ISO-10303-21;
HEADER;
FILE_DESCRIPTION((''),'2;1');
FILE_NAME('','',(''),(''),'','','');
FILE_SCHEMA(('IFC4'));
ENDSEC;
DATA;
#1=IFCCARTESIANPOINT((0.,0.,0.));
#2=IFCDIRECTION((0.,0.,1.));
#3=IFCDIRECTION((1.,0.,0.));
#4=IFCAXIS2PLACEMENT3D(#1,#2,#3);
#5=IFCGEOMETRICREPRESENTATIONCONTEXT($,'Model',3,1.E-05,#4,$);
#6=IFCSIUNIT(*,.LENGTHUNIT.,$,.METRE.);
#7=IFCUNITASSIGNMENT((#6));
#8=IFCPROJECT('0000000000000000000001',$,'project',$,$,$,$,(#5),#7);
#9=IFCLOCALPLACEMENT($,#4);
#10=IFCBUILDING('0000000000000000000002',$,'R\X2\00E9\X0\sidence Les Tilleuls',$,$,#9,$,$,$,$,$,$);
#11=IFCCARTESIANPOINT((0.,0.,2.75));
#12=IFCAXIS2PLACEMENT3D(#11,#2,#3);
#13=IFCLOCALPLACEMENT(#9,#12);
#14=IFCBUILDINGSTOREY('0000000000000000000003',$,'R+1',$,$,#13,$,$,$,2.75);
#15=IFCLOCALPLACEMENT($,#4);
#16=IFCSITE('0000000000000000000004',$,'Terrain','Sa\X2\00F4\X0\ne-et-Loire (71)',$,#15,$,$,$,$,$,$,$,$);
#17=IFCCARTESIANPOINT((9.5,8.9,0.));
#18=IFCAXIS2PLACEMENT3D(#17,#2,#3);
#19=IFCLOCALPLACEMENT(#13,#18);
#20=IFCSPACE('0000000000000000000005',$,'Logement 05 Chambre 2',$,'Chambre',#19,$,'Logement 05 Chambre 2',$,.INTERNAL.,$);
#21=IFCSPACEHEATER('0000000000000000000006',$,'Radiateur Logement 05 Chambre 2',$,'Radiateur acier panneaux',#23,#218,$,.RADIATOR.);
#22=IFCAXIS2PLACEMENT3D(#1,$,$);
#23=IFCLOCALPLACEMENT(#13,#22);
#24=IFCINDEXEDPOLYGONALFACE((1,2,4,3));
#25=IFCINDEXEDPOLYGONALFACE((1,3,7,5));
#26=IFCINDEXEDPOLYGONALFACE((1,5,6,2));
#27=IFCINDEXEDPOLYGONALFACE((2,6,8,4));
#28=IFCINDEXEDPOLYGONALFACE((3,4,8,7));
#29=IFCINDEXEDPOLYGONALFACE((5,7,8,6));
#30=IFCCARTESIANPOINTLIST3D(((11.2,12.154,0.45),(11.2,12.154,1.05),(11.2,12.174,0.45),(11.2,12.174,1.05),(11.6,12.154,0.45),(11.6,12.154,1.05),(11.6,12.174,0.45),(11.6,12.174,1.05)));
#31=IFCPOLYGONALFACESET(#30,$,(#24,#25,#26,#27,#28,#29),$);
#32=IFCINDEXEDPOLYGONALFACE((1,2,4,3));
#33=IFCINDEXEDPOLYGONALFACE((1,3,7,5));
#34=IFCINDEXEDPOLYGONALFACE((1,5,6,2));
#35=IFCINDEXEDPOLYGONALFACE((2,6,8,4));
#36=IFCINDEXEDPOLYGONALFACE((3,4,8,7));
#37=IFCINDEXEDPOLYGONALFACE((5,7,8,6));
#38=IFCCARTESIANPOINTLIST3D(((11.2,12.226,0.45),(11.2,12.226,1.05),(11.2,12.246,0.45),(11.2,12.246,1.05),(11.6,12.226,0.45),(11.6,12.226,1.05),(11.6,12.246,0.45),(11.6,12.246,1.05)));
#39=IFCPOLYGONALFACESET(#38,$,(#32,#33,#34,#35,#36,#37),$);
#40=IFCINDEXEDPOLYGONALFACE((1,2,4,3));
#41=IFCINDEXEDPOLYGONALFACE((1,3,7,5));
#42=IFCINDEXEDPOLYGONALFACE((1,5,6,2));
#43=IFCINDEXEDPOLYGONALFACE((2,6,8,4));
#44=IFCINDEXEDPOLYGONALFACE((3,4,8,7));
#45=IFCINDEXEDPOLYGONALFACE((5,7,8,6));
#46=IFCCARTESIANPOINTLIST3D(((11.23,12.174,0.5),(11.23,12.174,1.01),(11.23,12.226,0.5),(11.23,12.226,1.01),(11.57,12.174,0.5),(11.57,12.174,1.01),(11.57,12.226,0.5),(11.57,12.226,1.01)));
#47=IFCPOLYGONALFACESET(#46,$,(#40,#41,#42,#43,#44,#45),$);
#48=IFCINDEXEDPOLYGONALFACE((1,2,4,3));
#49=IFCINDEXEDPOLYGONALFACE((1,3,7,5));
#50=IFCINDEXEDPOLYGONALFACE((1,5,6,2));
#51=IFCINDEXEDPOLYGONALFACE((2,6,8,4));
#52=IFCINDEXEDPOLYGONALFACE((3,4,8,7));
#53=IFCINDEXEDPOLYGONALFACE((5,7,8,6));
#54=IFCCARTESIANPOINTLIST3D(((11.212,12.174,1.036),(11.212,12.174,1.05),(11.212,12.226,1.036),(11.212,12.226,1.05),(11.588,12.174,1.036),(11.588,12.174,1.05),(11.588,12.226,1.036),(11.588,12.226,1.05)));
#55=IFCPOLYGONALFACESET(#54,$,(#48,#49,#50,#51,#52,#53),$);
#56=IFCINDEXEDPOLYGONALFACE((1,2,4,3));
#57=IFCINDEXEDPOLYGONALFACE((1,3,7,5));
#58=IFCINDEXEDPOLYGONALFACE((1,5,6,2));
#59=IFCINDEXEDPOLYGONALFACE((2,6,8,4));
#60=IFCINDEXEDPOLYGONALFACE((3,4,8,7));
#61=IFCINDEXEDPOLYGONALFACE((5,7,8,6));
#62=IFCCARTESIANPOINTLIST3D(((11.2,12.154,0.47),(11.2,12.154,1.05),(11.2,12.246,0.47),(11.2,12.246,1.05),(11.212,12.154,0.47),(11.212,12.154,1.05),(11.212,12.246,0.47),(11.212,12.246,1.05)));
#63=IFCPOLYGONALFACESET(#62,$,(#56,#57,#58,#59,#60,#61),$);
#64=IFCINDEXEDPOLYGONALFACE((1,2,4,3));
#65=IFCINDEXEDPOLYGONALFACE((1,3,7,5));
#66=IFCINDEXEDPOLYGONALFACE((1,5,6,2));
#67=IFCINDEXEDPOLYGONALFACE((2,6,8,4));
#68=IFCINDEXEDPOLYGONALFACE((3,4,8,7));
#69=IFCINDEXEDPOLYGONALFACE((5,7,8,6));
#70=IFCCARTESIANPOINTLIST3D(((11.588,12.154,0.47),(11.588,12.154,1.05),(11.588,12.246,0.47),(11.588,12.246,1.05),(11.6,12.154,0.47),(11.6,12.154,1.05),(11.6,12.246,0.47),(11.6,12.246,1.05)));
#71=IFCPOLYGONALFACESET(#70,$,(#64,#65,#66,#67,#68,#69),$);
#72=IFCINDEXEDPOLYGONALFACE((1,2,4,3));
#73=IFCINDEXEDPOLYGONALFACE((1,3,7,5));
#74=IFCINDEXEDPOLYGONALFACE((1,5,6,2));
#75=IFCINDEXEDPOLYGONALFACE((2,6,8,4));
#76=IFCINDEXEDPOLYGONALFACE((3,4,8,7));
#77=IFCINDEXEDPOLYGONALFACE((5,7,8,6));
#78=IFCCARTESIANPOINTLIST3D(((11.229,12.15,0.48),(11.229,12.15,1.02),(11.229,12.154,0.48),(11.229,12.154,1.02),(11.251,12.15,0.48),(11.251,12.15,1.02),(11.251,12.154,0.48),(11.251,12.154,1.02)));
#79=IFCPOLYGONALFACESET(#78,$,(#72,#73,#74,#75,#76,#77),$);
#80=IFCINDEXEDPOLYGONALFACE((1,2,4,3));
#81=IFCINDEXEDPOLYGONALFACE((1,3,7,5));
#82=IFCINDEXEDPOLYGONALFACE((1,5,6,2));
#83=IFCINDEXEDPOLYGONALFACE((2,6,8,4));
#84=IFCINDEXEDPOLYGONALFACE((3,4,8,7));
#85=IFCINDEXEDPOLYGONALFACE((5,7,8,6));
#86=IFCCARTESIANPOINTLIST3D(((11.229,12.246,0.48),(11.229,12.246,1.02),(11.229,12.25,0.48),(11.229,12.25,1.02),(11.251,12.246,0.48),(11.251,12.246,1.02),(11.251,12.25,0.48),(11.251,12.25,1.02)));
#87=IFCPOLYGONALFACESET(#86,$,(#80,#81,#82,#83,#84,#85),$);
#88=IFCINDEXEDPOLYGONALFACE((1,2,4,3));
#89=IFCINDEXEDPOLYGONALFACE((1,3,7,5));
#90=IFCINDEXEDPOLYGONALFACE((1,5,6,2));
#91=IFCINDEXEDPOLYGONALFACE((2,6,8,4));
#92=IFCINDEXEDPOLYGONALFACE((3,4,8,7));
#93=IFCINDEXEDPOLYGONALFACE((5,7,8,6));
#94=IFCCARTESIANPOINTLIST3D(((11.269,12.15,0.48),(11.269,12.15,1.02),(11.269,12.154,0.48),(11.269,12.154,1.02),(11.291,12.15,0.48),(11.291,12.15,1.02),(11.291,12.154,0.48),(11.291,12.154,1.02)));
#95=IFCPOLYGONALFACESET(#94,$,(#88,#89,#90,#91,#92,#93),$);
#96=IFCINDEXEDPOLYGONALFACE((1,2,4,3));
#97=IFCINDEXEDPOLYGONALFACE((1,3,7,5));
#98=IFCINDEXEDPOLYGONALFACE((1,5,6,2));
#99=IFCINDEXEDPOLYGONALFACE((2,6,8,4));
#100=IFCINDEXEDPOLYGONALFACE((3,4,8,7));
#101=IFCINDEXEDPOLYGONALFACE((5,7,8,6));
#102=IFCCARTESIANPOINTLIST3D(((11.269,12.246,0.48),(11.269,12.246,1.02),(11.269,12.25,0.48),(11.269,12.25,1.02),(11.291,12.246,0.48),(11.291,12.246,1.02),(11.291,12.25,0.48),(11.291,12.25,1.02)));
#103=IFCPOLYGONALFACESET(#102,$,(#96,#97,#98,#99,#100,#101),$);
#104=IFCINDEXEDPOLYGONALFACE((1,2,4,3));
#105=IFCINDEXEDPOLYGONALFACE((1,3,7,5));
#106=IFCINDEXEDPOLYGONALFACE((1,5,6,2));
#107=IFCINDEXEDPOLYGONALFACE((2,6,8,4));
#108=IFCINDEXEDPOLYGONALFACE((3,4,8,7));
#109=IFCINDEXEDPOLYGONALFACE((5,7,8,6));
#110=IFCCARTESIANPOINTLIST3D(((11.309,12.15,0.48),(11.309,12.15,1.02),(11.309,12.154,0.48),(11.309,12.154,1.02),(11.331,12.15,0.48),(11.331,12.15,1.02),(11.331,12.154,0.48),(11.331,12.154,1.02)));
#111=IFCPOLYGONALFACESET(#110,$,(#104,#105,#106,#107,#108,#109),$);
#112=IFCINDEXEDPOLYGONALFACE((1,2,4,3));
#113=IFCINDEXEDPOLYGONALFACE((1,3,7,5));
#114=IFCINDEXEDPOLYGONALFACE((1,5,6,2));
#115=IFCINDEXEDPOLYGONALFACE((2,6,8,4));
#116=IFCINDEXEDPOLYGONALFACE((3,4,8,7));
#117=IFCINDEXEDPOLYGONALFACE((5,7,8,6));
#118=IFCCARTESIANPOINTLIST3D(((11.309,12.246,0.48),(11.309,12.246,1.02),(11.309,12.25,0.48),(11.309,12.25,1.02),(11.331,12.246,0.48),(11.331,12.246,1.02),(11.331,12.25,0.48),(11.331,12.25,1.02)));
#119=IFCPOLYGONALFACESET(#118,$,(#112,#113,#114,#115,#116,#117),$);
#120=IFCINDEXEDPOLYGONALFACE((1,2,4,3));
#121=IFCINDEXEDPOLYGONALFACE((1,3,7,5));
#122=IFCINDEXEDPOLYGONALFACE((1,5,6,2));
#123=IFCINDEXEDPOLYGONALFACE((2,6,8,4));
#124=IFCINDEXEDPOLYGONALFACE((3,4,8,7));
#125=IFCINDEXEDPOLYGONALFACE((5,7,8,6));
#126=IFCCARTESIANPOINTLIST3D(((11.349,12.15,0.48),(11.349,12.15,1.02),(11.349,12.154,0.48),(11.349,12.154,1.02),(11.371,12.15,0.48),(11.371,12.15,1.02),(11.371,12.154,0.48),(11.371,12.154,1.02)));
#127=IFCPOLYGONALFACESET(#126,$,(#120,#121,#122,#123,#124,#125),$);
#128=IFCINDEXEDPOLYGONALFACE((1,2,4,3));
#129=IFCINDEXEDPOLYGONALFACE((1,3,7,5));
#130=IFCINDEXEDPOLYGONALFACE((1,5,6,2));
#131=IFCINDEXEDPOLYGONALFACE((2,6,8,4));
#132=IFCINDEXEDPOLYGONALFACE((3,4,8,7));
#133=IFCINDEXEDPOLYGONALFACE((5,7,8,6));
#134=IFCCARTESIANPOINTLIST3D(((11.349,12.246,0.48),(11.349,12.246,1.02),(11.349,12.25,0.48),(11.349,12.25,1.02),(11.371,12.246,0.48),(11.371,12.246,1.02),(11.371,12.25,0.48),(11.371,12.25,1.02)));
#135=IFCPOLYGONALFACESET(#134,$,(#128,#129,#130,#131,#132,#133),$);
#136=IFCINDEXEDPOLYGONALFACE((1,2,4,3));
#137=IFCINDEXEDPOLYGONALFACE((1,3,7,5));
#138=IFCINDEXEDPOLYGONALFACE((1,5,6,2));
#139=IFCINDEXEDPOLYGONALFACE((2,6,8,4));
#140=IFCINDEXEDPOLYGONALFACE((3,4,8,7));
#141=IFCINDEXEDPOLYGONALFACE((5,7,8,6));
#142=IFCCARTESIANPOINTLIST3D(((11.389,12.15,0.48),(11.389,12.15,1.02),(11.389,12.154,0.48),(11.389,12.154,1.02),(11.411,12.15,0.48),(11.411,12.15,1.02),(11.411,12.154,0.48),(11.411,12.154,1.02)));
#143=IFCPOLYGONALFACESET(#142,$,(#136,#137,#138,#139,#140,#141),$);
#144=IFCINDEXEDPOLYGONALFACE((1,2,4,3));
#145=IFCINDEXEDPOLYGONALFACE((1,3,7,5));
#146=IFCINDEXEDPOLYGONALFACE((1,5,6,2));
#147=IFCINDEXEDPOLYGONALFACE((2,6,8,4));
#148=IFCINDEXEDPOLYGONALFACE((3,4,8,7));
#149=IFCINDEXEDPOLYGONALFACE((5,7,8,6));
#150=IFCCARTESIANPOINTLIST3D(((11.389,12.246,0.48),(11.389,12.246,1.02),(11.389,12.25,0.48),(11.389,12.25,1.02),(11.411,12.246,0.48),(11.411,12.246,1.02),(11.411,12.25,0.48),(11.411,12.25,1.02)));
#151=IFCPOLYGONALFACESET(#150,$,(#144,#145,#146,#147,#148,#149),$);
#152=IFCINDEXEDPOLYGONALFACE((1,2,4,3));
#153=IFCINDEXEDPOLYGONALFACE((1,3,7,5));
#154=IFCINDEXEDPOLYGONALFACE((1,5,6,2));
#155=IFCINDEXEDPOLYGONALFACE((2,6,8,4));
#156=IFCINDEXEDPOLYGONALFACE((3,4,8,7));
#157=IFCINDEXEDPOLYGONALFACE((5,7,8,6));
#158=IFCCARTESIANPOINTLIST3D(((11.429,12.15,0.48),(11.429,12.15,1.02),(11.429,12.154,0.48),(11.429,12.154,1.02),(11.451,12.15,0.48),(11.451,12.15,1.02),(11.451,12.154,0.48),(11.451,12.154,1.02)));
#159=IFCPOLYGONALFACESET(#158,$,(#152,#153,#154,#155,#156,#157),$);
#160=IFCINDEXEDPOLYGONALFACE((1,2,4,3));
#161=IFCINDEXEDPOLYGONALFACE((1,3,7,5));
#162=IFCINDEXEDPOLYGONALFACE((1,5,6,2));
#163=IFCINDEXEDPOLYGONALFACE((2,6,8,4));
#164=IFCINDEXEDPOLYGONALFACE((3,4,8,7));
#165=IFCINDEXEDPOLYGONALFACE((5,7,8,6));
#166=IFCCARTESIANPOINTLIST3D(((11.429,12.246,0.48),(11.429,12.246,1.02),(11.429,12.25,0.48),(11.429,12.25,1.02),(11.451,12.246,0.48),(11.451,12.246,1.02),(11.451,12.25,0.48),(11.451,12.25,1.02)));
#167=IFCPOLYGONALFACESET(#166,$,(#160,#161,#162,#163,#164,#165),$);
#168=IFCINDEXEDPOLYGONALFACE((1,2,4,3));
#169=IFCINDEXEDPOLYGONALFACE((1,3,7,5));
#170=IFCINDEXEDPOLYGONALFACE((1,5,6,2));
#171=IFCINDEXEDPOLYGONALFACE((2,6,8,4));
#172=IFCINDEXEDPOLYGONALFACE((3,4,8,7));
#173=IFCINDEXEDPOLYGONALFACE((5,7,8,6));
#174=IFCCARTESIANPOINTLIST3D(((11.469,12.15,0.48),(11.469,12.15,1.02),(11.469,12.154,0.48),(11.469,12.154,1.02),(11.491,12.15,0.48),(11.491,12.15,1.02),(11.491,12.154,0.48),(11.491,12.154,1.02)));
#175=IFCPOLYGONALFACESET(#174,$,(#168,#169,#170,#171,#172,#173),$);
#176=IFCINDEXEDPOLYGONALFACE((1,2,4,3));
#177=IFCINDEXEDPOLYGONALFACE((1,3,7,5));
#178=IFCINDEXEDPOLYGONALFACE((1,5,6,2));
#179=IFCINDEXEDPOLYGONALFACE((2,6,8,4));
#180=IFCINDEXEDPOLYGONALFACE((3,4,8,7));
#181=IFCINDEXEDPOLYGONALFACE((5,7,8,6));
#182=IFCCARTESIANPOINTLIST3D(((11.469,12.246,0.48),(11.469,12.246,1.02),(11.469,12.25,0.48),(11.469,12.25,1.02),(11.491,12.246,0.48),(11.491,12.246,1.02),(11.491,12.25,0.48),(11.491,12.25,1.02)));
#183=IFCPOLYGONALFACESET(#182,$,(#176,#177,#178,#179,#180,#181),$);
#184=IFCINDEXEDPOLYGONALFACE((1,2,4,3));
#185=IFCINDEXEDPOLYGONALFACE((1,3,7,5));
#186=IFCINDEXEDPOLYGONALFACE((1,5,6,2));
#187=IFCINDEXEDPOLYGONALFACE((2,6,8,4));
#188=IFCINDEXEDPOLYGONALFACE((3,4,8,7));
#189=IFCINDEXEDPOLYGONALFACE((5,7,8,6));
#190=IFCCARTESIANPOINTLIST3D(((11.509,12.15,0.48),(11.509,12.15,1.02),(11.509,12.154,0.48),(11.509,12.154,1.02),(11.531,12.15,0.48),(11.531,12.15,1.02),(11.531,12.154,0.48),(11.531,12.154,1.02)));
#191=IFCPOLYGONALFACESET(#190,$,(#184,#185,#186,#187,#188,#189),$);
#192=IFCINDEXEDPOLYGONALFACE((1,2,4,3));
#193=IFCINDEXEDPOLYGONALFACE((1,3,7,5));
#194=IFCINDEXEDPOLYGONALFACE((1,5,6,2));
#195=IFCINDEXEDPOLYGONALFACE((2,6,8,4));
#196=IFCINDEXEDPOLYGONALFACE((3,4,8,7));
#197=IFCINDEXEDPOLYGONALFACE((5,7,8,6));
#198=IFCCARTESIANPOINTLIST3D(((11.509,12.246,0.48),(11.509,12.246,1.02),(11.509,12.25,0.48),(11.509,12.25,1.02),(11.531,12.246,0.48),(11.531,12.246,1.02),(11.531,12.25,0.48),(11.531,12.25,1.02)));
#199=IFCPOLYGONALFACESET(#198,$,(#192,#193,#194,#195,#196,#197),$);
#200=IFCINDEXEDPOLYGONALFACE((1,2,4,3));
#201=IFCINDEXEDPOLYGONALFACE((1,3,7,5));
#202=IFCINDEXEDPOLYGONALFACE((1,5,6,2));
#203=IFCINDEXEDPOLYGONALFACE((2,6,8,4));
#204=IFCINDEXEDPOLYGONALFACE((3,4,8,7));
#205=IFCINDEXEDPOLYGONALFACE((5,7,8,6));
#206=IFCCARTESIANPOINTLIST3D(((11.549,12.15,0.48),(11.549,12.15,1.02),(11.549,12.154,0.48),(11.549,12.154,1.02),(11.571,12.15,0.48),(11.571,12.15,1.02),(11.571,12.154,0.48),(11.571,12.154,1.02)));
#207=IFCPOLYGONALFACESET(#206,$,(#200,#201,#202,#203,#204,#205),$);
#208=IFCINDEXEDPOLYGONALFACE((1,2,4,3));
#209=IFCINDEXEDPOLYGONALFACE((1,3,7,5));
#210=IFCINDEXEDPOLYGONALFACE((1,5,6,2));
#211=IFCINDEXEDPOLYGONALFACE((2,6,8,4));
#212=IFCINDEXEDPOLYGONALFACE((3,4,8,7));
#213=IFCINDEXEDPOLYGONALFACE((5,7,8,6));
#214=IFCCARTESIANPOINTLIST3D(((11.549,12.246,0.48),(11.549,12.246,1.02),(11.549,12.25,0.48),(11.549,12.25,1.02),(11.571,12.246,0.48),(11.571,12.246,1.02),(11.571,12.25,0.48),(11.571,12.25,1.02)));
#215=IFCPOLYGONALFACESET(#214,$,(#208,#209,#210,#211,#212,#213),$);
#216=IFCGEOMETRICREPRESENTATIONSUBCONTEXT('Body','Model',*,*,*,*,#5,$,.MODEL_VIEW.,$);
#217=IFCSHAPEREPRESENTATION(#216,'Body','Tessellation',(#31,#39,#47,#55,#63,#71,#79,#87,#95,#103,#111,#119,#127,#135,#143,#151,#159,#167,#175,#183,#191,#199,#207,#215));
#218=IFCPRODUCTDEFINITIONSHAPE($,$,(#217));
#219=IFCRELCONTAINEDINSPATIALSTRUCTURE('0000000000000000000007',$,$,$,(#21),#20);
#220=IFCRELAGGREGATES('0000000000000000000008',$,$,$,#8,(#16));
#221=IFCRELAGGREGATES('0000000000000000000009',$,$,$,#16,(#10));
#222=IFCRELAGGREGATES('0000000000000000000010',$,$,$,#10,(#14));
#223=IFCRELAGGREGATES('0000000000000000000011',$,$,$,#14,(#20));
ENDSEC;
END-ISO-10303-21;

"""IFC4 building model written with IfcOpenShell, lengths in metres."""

from ifc_helpers import new_model, si_unit, frame, frame_2d, origin_with_axes, place, context, subcontext, project, spatial, rectangle, extrude, element, save


model = new_model("IFC4")

# Units and contexts
model_context = context("Model", 3, precision=1e-05, world=origin_with_axes())
body_context = subcontext(model_context, "Body", "Model", "MODEL_VIEW")
ifc_project = project(units=[si_unit("LENGTHUNIT", "METRE")], contexts=[model_context])

# Site, building, storey
site_placement = place(None, origin_with_axes())
site = spatial("IfcSite", under=ifc_project, at=site_placement, Name="Terrain", Description="Saône-et-Loire (71)")
building_placement = place(None, origin_with_axes())
building = spatial("IfcBuilding", under=site, at=building_placement, Name="Résidence Les Tilleuls")
storey_placement = place(building_placement, frame((0.0, 0.0, 2.75), z_axis=(0.0, 0.0, 1.0), x_axis=(1.0, 0.0, 0.0)))
storey = spatial("IfcBuildingStorey", under=building, at=storey_placement, Name="R+1", Elevation=2.75)

# Shared definitions
space_1_placement = place(storey_placement, frame((9.5, 8.9, 0.0), z_axis=(0.0, 0.0, 1.0), x_axis=(1.0, 0.0, 0.0)))
space_1 = spatial("IfcSpace", under=storey, at=space_1_placement, Name="Logement 05 Chambre 2", ObjectType="Chambre", LongName="Logement 05 Chambre 2", PredefinedType="INTERNAL")

# Space heater
space_heater_placement = place(space_1_placement, frame((1.7, 3.25, 0.45), z_axis=(0.0, 0.0, 1.0), x_axis=(1.0, 0.0, 0.0)))
element("IfcSpaceHeater", 1, at=space_heater_placement, inside=space_1, Name="Radiateur Logement 05 Chambre 2", ObjectType="Radiateur acier panneaux", PredefinedType="RADIATOR", context=body_context, shape_type="SweptSolid", body=[
    extrude(rectangle(XDim=0.4, YDim=0.02, at=frame_2d((0.2, 0.01))), frame((0.0, 0.004, 0.0), z_axis=(0.0, 0.0, 1.0), x_axis=(1.0, 0.0, 0.0)), (0.0, 0.0, 1.0), 0.6),
    extrude(rectangle(XDim=0.4, YDim=0.02, at=frame_2d((0.2, 0.01))), frame((0.0, 0.076, 0.0), z_axis=(0.0, 0.0, 1.0), x_axis=(1.0, 0.0, 0.0)), (0.0, 0.0, 1.0), 0.6),
    extrude(rectangle(XDim=0.34, YDim=0.052, at=frame_2d((0.17, 0.026))), frame((0.03, 0.024, 0.05), z_axis=(0.0, 0.0, 1.0), x_axis=(1.0, 0.0, 0.0)), (0.0, 0.0, 1.0), 0.51),
    extrude(rectangle(XDim=0.376, YDim=0.052, at=frame_2d((0.188, 0.026))), frame((0.012, 0.024, 0.586), z_axis=(0.0, 0.0, 1.0), x_axis=(1.0, 0.0, 0.0)), (0.0, 0.0, 1.0), 0.014),
    extrude(rectangle(XDim=0.012, YDim=0.092, at=frame_2d((0.006, 0.046))), frame((0.0, 0.004, 0.02), z_axis=(0.0, 0.0, 1.0), x_axis=(1.0, 0.0, 0.0)), (0.0, 0.0, 1.0), 0.58),
    extrude(rectangle(XDim=0.012, YDim=0.092, at=frame_2d((0.006, 0.046))), frame((0.388, 0.004, 0.02), z_axis=(0.0, 0.0, 1.0), x_axis=(1.0, 0.0, 0.0)), (0.0, 0.0, 1.0), 0.58),
    extrude(rectangle(XDim=0.022, YDim=0.004, at=frame_2d((0.011, 0.002))), frame((0.029, 0.0, 0.03), z_axis=(0.0, 0.0, 1.0), x_axis=(1.0, 0.0, 0.0)), (0.0, 0.0, 1.0), 0.54),
    extrude(rectangle(XDim=0.022, YDim=0.004, at=frame_2d((0.011, 0.002))), frame((0.029, 0.096, 0.03), z_axis=(0.0, 0.0, 1.0), x_axis=(1.0, 0.0, 0.0)), (0.0, 0.0, 1.0), 0.54),
    extrude(rectangle(XDim=0.022, YDim=0.004, at=frame_2d((0.011, 0.002))), frame((0.069, 0.0, 0.03), z_axis=(0.0, 0.0, 1.0), x_axis=(1.0, 0.0, 0.0)), (0.0, 0.0, 1.0), 0.54),
    extrude(rectangle(XDim=0.022, YDim=0.004, at=frame_2d((0.011, 0.002))), frame((0.069, 0.096, 0.03), z_axis=(0.0, 0.0, 1.0), x_axis=(1.0, 0.0, 0.0)), (0.0, 0.0, 1.0), 0.54),
    extrude(rectangle(XDim=0.022, YDim=0.004, at=frame_2d((0.011, 0.002))), frame((0.109, 0.0, 0.03), z_axis=(0.0, 0.0, 1.0), x_axis=(1.0, 0.0, 0.0)), (0.0, 0.0, 1.0), 0.54),
    extrude(rectangle(XDim=0.022, YDim=0.004, at=frame_2d((0.011, 0.002))), frame((0.109, 0.096, 0.03), z_axis=(0.0, 0.0, 1.0), x_axis=(1.0, 0.0, 0.0)), (0.0, 0.0, 1.0), 0.54),
    extrude(rectangle(XDim=0.022, YDim=0.004, at=frame_2d((0.011, 0.002))), frame((0.149, 0.0, 0.03), z_axis=(0.0, 0.0, 1.0), x_axis=(1.0, 0.0, 0.0)), (0.0, 0.0, 1.0), 0.54),
    extrude(rectangle(XDim=0.022, YDim=0.004, at=frame_2d((0.011, 0.002))), frame((0.149, 0.096, 0.03), z_axis=(0.0, 0.0, 1.0), x_axis=(1.0, 0.0, 0.0)), (0.0, 0.0, 1.0), 0.54),
    extrude(rectangle(XDim=0.022, YDim=0.004, at=frame_2d((0.011, 0.002))), frame((0.189, 0.0, 0.03), z_axis=(0.0, 0.0, 1.0), x_axis=(1.0, 0.0, 0.0)), (0.0, 0.0, 1.0), 0.54),
    extrude(rectangle(XDim=0.022, YDim=0.004, at=frame_2d((0.011, 0.002))), frame((0.189, 0.096, 0.03), z_axis=(0.0, 0.0, 1.0), x_axis=(1.0, 0.0, 0.0)), (0.0, 0.0, 1.0), 0.54),
    extrude(rectangle(XDim=0.022, YDim=0.004, at=frame_2d((0.011, 0.002))), frame((0.229, 0.0, 0.03), z_axis=(0.0, 0.0, 1.0), x_axis=(1.0, 0.0, 0.0)), (0.0, 0.0, 1.0), 0.54),
    extrude(rectangle(XDim=0.022, YDim=0.004, at=frame_2d((0.011, 0.002))), frame((0.229, 0.096, 0.03), z_axis=(0.0, 0.0, 1.0), x_axis=(1.0, 0.0, 0.0)), (0.0, 0.0, 1.0), 0.54),
    extrude(rectangle(XDim=0.022, YDim=0.004, at=frame_2d((0.011, 0.002))), frame((0.269, 0.0, 0.03), z_axis=(0.0, 0.0, 1.0), x_axis=(1.0, 0.0, 0.0)), (0.0, 0.0, 1.0), 0.54),
    extrude(rectangle(XDim=0.022, YDim=0.004, at=frame_2d((0.011, 0.002))), frame((0.269, 0.096, 0.03), z_axis=(0.0, 0.0, 1.0), x_axis=(1.0, 0.0, 0.0)), (0.0, 0.0, 1.0), 0.54),
    extrude(rectangle(XDim=0.022, YDim=0.004, at=frame_2d((0.011, 0.002))), frame((0.309, 0.0, 0.03), z_axis=(0.0, 0.0, 1.0), x_axis=(1.0, 0.0, 0.0)), (0.0, 0.0, 1.0), 0.54),
    extrude(rectangle(XDim=0.022, YDim=0.004, at=frame_2d((0.011, 0.002))), frame((0.309, 0.096, 0.03), z_axis=(0.0, 0.0, 1.0), x_axis=(1.0, 0.0, 0.0)), (0.0, 0.0, 1.0), 0.54),
    extrude(rectangle(XDim=0.022, YDim=0.004, at=frame_2d((0.011, 0.002))), frame((0.349, 0.0, 0.03), z_axis=(0.0, 0.0, 1.0), x_axis=(1.0, 0.0, 0.0)), (0.0, 0.0, 1.0), 0.54),
    extrude(rectangle(XDim=0.022, YDim=0.004, at=frame_2d((0.011, 0.002))), frame((0.349, 0.096, 0.03), z_axis=(0.0, 0.0, 1.0), x_axis=(1.0, 0.0, 0.0)), (0.0, 0.0, 1.0), 0.54),
])

save(model, "model.ifc")
